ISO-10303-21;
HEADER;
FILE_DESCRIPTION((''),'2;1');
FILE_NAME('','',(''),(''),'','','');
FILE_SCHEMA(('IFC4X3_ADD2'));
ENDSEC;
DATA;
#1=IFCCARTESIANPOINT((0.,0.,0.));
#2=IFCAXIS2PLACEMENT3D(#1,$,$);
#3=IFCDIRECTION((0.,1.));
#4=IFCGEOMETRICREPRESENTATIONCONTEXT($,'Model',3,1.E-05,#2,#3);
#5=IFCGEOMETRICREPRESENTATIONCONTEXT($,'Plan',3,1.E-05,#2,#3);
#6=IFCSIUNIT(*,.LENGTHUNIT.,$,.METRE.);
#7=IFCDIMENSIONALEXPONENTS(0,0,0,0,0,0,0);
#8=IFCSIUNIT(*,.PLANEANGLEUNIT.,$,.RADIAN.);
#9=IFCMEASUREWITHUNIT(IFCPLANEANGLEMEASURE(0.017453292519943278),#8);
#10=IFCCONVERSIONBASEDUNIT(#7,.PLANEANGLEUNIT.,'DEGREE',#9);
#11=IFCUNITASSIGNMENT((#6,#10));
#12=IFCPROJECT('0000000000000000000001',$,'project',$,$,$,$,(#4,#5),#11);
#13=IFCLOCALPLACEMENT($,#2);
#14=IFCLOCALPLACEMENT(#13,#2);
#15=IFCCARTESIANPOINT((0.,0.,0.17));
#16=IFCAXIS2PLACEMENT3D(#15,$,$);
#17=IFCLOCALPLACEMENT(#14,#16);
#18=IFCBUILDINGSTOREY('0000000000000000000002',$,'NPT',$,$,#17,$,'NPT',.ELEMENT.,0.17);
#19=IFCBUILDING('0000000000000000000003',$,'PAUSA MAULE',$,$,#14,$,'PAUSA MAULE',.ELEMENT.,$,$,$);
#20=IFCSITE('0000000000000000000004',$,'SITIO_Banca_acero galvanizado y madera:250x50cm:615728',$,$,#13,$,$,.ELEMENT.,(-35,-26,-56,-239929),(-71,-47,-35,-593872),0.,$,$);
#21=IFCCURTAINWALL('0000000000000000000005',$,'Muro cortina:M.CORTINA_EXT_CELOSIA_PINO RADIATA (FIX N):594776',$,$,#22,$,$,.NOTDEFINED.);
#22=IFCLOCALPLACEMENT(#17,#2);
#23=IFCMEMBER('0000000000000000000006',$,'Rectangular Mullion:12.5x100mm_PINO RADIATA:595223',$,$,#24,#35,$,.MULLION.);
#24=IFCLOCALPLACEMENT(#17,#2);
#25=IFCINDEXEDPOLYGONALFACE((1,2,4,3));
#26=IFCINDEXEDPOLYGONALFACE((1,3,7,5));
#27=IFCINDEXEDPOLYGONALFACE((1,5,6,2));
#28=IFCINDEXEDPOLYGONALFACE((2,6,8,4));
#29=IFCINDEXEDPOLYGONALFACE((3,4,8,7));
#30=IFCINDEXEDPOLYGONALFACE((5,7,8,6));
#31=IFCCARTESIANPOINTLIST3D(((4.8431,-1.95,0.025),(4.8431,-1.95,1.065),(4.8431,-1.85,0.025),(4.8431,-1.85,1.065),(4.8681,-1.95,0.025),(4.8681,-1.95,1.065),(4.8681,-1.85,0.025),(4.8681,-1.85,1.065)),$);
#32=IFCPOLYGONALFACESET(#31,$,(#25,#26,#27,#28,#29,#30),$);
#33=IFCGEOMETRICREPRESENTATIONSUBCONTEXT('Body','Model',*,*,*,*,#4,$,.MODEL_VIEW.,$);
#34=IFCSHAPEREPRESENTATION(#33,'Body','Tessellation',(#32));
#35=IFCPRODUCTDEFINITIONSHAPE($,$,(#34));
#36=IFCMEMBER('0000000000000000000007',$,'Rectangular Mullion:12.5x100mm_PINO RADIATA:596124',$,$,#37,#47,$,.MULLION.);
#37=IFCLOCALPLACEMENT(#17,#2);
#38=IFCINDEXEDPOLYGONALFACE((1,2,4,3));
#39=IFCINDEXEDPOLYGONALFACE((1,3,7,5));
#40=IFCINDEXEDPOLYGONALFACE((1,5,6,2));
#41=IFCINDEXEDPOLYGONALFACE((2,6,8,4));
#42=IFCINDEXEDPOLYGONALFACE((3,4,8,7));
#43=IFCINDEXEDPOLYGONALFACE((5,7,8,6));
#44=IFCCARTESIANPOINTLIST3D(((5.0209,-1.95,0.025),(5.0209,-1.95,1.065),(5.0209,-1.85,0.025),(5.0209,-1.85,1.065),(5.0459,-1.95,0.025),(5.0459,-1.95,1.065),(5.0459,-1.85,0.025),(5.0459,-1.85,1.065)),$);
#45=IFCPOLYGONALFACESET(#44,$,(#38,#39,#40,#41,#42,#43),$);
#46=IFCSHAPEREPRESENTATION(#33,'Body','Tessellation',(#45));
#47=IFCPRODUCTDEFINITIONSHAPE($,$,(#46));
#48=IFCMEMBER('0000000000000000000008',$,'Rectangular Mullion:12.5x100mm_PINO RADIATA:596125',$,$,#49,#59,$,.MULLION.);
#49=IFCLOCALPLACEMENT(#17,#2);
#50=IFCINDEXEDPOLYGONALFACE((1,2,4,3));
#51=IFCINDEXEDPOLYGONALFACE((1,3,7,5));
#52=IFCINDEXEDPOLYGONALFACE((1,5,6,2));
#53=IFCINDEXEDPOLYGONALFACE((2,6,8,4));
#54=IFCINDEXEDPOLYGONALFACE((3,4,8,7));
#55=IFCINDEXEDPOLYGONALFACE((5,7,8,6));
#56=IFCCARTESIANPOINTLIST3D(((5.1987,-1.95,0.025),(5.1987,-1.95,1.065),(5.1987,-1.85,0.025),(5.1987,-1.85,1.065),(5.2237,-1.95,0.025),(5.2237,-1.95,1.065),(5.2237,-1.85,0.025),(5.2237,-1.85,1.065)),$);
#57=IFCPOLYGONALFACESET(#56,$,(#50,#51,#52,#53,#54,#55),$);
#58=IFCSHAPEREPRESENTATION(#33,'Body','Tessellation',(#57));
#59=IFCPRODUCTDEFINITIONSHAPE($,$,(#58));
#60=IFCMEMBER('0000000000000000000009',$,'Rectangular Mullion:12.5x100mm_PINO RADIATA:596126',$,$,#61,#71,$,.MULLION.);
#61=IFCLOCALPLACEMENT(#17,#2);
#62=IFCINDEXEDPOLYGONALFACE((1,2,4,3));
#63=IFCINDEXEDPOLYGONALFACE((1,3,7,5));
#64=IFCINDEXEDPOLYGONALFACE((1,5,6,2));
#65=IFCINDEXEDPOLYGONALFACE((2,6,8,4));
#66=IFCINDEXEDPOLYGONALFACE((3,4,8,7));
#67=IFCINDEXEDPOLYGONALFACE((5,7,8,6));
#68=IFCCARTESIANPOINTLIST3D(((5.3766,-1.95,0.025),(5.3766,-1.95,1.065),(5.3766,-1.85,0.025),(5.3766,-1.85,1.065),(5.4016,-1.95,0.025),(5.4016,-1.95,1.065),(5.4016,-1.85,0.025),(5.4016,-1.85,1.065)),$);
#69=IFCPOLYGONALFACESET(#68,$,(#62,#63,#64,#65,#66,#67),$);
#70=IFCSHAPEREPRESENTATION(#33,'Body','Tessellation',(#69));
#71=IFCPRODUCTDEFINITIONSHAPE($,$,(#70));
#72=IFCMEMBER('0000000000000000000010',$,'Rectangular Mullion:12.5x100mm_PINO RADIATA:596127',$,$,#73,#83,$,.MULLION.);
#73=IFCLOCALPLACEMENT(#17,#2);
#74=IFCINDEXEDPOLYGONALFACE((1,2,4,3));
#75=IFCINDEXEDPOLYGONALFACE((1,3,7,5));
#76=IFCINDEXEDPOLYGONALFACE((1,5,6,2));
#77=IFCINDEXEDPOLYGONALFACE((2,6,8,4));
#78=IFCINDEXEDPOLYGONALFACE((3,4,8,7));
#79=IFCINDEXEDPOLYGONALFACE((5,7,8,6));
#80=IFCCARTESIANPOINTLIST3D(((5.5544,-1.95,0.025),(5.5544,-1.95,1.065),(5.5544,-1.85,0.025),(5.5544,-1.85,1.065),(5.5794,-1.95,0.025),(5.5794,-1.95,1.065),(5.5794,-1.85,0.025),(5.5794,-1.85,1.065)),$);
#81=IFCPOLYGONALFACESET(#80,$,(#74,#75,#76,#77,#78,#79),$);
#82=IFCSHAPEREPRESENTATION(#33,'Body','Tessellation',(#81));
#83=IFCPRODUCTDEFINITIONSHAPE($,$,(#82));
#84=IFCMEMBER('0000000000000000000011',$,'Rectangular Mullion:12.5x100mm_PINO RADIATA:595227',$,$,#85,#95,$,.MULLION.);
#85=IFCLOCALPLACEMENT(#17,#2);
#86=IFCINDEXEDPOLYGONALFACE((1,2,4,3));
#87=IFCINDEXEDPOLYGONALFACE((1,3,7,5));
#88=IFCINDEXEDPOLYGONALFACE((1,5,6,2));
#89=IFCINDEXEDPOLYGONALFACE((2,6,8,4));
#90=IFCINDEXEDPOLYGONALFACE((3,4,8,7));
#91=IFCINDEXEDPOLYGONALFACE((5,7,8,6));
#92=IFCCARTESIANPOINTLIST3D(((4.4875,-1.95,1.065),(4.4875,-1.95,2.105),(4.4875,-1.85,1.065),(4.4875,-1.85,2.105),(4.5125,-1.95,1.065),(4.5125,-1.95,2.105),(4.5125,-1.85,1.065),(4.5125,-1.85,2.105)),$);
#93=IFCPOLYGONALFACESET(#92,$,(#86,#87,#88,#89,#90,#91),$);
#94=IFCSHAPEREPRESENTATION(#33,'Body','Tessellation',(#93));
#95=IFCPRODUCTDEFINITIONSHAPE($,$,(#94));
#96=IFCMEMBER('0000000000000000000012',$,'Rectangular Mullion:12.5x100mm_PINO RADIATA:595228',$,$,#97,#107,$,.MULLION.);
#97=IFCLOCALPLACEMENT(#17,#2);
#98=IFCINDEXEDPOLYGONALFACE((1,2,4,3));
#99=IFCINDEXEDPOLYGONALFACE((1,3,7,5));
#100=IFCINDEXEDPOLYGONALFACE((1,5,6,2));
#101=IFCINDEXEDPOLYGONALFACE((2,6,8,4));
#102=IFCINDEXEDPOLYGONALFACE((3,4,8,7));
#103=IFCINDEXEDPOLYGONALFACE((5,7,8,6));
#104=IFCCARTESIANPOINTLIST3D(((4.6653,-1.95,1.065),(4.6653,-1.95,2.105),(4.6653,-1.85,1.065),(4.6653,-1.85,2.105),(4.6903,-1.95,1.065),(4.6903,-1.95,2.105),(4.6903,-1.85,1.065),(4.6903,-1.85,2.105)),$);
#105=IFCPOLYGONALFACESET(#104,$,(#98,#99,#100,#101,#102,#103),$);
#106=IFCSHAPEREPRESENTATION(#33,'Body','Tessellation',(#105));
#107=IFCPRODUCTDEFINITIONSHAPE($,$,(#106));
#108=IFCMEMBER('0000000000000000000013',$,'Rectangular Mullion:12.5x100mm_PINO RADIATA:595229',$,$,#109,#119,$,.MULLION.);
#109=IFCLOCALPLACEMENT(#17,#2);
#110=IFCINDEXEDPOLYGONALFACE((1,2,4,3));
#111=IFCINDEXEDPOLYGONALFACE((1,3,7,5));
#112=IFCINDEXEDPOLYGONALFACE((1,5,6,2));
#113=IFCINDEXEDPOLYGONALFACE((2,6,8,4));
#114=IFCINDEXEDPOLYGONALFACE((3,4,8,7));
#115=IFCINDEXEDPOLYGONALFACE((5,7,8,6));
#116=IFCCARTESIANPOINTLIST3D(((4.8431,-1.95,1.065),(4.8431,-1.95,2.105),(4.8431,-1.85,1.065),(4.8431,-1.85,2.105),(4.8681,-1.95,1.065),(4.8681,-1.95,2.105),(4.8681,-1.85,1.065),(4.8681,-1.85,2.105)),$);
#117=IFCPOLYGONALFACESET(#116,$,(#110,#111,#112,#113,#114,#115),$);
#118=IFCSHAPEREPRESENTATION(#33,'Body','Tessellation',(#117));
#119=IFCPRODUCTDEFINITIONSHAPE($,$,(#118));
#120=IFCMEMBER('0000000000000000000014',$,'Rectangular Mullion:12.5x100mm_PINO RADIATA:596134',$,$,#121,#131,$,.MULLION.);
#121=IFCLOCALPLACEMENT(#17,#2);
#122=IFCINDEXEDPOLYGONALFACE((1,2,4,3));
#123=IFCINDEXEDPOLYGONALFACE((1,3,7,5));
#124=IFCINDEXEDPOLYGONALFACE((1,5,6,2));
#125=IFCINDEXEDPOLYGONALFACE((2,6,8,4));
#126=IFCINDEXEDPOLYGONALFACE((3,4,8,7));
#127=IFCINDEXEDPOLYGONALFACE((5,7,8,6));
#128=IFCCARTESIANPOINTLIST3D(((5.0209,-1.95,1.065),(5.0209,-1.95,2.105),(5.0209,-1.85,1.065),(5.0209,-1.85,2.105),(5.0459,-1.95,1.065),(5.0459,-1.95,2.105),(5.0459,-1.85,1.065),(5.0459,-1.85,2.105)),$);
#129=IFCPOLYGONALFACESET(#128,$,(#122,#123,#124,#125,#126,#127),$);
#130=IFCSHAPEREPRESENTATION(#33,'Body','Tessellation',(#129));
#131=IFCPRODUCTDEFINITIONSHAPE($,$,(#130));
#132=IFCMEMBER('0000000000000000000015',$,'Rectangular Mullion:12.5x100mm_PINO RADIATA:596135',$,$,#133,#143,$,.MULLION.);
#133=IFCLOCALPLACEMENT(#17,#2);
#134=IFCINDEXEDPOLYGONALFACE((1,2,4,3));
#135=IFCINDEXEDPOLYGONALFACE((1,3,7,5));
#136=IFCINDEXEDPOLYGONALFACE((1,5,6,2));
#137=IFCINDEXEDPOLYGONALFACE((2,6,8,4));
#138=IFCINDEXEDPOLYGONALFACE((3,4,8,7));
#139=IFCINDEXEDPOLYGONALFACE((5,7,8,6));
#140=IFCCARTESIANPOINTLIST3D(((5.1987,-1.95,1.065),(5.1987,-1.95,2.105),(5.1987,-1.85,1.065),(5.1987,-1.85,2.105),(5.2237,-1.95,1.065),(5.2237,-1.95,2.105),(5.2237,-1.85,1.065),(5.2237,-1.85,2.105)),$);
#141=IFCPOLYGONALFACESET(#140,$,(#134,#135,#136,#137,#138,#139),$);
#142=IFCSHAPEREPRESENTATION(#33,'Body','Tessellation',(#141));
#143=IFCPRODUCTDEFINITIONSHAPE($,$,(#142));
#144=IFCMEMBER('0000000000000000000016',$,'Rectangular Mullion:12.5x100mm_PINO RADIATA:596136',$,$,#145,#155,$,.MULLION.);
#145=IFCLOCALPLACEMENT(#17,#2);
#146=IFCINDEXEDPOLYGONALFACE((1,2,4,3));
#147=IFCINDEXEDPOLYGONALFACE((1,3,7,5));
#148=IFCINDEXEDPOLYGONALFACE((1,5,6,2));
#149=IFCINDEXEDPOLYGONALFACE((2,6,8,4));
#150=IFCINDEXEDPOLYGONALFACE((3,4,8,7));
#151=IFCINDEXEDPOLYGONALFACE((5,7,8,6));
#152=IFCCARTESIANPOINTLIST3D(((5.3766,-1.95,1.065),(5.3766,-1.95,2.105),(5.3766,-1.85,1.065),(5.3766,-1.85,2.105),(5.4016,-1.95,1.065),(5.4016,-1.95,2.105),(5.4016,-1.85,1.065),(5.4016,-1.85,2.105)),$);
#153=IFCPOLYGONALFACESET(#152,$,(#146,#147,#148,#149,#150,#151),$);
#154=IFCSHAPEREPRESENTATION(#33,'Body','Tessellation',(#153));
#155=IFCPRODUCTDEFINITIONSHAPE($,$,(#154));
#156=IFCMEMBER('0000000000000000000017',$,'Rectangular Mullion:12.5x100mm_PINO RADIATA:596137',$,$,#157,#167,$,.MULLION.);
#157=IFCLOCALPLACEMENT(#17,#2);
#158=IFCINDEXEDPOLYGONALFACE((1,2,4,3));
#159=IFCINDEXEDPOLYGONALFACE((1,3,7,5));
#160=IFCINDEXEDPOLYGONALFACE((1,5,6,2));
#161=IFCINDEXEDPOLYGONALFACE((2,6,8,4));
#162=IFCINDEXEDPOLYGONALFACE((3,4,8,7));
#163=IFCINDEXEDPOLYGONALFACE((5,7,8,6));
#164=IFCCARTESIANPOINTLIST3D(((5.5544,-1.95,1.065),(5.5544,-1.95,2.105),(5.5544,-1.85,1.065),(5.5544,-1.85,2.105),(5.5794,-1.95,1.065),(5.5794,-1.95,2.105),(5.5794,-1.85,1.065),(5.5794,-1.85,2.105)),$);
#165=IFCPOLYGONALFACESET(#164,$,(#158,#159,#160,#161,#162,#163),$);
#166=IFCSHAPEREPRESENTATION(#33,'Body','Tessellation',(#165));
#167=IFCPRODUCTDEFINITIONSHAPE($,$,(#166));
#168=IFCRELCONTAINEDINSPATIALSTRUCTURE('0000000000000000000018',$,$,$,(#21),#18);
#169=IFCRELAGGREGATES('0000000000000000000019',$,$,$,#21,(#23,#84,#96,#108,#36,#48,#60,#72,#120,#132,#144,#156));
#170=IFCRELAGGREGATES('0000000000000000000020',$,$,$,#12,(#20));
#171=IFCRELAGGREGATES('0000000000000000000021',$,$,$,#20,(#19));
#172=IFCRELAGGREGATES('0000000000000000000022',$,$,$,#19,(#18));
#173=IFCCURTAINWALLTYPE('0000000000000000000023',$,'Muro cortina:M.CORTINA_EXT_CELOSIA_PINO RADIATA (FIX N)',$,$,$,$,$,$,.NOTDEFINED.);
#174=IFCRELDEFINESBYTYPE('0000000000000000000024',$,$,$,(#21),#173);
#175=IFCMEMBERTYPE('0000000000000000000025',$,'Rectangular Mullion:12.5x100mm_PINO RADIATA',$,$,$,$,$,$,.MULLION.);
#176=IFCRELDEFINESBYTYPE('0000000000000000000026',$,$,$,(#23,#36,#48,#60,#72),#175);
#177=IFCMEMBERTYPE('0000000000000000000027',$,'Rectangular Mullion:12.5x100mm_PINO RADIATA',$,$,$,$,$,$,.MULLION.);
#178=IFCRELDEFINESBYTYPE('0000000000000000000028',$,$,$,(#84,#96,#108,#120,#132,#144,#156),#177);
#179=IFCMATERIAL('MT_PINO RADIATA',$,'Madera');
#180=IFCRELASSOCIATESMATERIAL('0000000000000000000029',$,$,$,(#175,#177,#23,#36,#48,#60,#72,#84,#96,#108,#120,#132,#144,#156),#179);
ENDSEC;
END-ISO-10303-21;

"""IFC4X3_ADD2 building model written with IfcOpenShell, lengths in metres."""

from ifc_helpers import new_model, entity, si_unit, converted_unit, direction, frame, frame_2d, origin, origin_2d_with_axis, place, context, subcontext, project, spatial, rectangle, extrude, source, transform, mapped, material, material_profile, profile_set, profile_usage, type_object, type_shapes, element, aggregate, save


model = new_model("IFC4X3_ADD2")

# Units and contexts
model_context = context("Model", 3, precision=1e-05, world=origin(), true_north=direction((0.0, 1.0)))
plan_context = context("Plan", 3, precision=1e-05, world=origin(), true_north=direction((0.0, 1.0)))
body_context = subcontext(model_context, "Body", "Model", "MODEL_VIEW")
ifc_project = project(units=[si_unit("LENGTHUNIT", "METRE"), converted_unit("PLANEANGLEUNIT", "DEGREE", entity("IfcPlaneAngleMeasure", 0.017453292519943278), si_unit("PLANEANGLEUNIT", "RADIAN"), dimensions=[0, 0, 0, 0, 0, 0, 0])], contexts=[model_context, plan_context])

# Site, building, storey
site_placement = place(None, origin())
site = spatial("IfcSite", under=ifc_project, at=site_placement, Name="SITIO_Banca_acero galvanizado y madera:250x50cm:615728", CompositionType="ELEMENT", RefLatitude=(-35, -26, -56, -239929), RefLongitude=(-71, -47, -35, -593872), RefElevation=0.0)
building_placement = place(site_placement, origin())
building = spatial("IfcBuilding", under=site, at=building_placement, Name="PAUSA MAULE", LongName="PAUSA MAULE", CompositionType="ELEMENT")
storey_placement = place(building_placement, frame((0.0, 0.0, 0.17)))
storey = spatial("IfcBuildingStorey", under=building, at=storey_placement, Name="NPT", LongName="NPT", CompositionType="ELEMENT", Elevation=0.17)

# Curtain wall, members
curtain_wall_type = type_object("IfcCurtainWallType", Name="Muro cortina:M.CORTINA_EXT_CELOSIA_PINO RADIATA (FIX N)", PredefinedType="NOTDEFINED")
curtain_wall_placement = place(storey_placement, frame((0.0, 0.0, -0.17)))
curtain_wall = element("IfcCurtainWall", 1, at=curtain_wall_placement, inside=storey, type_object=curtain_wall_type, Name="Muro cortina:M.CORTINA_EXT_CELOSIA_PINO RADIATA (FIX N):594776", PredefinedType="NOTDEFINED")
ifc_material = material(Name="MT_PINO RADIATA", Category="Madera")
ifc_material_profile = material_profile(ifc_material, rectangle(XDim=0.025, YDim=0.1, at=frame_2d((0.0, 0.0), x_axis=(1.0, 0.0))), Name="12.5x100mm_PINO RADIATA")
ifc_profile_set = profile_set([ifc_material_profile], Name="12.5x100mm_PINO RADIATA")
ifc_profile_usage = profile_usage(ifc_profile_set)
member_type_1 = type_object("IfcMemberType", Name="Rectangular Mullion:12.5x100mm_PINO RADIATA", PredefinedType="MULLION", material=ifc_profile_set)
shared_shape_1 = source(origin(), body_context, "Body", "SweptSolid", [
    extrude(rectangle(XDim=0.025, YDim=0.1, at=frame_2d((0.0, 0.0), x_axis=(1.0, 0.0))), frame((0.0, 0.0, -1.04), z_axis=(0.0, 0.0, 1.0), x_axis=(-1.0, 0.0, 0.0)), (0.0, 0.0, 1.0), 1.04),
])
type_shapes(member_type_1, [shared_shape_1])
member_1_placement = place(curtain_wall_placement, frame((4.8556, -1.9, 0.195), z_axis=(0.0, 0.0, -1.0), x_axis=(1.0, 0.0, 0.0)))
member_1 = element("IfcMember", 2, at=member_1_placement, type_object=member_type_1, material=ifc_profile_usage, Name="Rectangular Mullion:12.5x100mm_PINO RADIATA:595223", PredefinedType="MULLION", context=body_context, shape_type="MappedRepresentation", body=[
    mapped(shared_shape_1, transform((0.0, 0.0, 0.0), scale=1.0)),
])
member_2_placement = place(curtain_wall_placement, frame((5.0334, -1.9, 0.195), z_axis=(0.0, 0.0, -1.0), x_axis=(1.0, 0.0, 0.0)))
member_2 = element("IfcMember", 3, at=member_2_placement, type_object=member_type_1, material=ifc_profile_usage, Name="Rectangular Mullion:12.5x100mm_PINO RADIATA:596124", PredefinedType="MULLION", context=body_context, shape_type="MappedRepresentation", body=[
    mapped(shared_shape_1, transform((0.0, 0.0, 0.0), scale=1.0)),
])
member_3_placement = place(curtain_wall_placement, frame((5.2112, -1.9, 0.195), z_axis=(0.0, 0.0, -1.0), x_axis=(1.0, 0.0, 0.0)))
member_3 = element("IfcMember", 4, at=member_3_placement, type_object=member_type_1, material=ifc_profile_usage, Name="Rectangular Mullion:12.5x100mm_PINO RADIATA:596125", PredefinedType="MULLION", context=body_context, shape_type="MappedRepresentation", body=[
    mapped(shared_shape_1, transform((0.0, 0.0, 0.0), scale=1.0)),
])
member_4_placement = place(curtain_wall_placement, frame((5.3891, -1.9, 0.195), z_axis=(0.0, 0.0, -1.0), x_axis=(1.0, 0.0, 0.0)))
member_4 = element("IfcMember", 5, at=member_4_placement, type_object=member_type_1, material=ifc_profile_usage, Name="Rectangular Mullion:12.5x100mm_PINO RADIATA:596126", PredefinedType="MULLION", context=body_context, shape_type="MappedRepresentation", body=[
    mapped(shared_shape_1, transform((0.0, 0.0, 0.0), scale=1.0)),
])
member_5_placement = place(curtain_wall_placement, frame((5.5669, -1.9, 0.195), z_axis=(0.0, 0.0, -1.0), x_axis=(1.0, 0.0, 0.0)))
member_5 = element("IfcMember", 6, at=member_5_placement, type_object=member_type_1, material=ifc_profile_usage, Name="Rectangular Mullion:12.5x100mm_PINO RADIATA:596127", PredefinedType="MULLION", context=body_context, shape_type="MappedRepresentation", body=[
    mapped(shared_shape_1, transform((0.0, 0.0, 0.0), scale=1.0)),
])
member_type_2 = type_object("IfcMemberType", Name="Rectangular Mullion:12.5x100mm_PINO RADIATA", PredefinedType="MULLION", material=ifc_profile_set)
shared_shape_2 = source(origin(), body_context, "Body", "SweptSolid", [
    extrude(rectangle(XDim=0.025, YDim=0.1, at=origin_2d_with_axis()), frame((0.0, 0.0, -1.04), z_axis=(0.0, 0.0, 1.0), x_axis=(-1.0, 0.0, 0.0)), (0.0, 0.0, 1.0), 1.04),
])
type_shapes(member_type_2, [shared_shape_2])
member_6_placement = place(curtain_wall_placement, frame((4.5, -1.9, 1.235), z_axis=(0.0, 0.0, -1.0), x_axis=(1.0, 0.0, 0.0)))
member_6 = element("IfcMember", 7, at=member_6_placement, type_object=member_type_2, material=ifc_profile_usage, Name="Rectangular Mullion:12.5x100mm_PINO RADIATA:595227", PredefinedType="MULLION", context=body_context, shape_type="MappedRepresentation", body=[
    mapped(shared_shape_2, transform((0.0, 0.0, 0.0), scale=1.0)),
])
member_7_placement = place(curtain_wall_placement, frame((4.6778, -1.9, 1.235), z_axis=(0.0, 0.0, -1.0), x_axis=(1.0, 0.0, 0.0)))
member_7 = element("IfcMember", 8, at=member_7_placement, type_object=member_type_2, material=ifc_profile_usage, Name="Rectangular Mullion:12.5x100mm_PINO RADIATA:595228", PredefinedType="MULLION", context=body_context, shape_type="MappedRepresentation", body=[
    mapped(shared_shape_2, transform((0.0, 0.0, 0.0), scale=1.0)),
])
member_8_placement = place(curtain_wall_placement, frame((4.8556, -1.9, 1.235), z_axis=(0.0, 0.0, -1.0), x_axis=(1.0, 0.0, 0.0)))
member_8 = element("IfcMember", 9, at=member_8_placement, type_object=member_type_2, material=ifc_profile_usage, Name="Rectangular Mullion:12.5x100mm_PINO RADIATA:595229", PredefinedType="MULLION", context=body_context, shape_type="MappedRepresentation", body=[
    mapped(shared_shape_2, transform((0.0, 0.0, 0.0), scale=1.0)),
])
member_9_placement = place(curtain_wall_placement, frame((5.0334, -1.9, 1.235), z_axis=(0.0, 0.0, -1.0), x_axis=(1.0, 0.0, 0.0)))
member_9 = element("IfcMember", 10, at=member_9_placement, type_object=member_type_2, material=ifc_profile_usage, Name="Rectangular Mullion:12.5x100mm_PINO RADIATA:596134", PredefinedType="MULLION", context=body_context, shape_type="MappedRepresentation", body=[
    mapped(shared_shape_2, transform((0.0, 0.0, 0.0), scale=1.0)),
])
member_10_placement = place(curtain_wall_placement, frame((5.2112, -1.9, 1.235), z_axis=(0.0, 0.0, -1.0), x_axis=(1.0, 0.0, 0.0)))
member_10 = element("IfcMember", 11, at=member_10_placement, type_object=member_type_2, material=ifc_profile_usage, Name="Rectangular Mullion:12.5x100mm_PINO RADIATA:596135", PredefinedType="MULLION", context=body_context, shape_type="MappedRepresentation", body=[
    mapped(shared_shape_2, transform((0.0, 0.0, 0.0), scale=1.0)),
])
member_11_placement = place(curtain_wall_placement, frame((5.3891, -1.9, 1.235), z_axis=(0.0, 0.0, -1.0), x_axis=(1.0, 0.0, 0.0)))
member_11 = element("IfcMember", 12, at=member_11_placement, type_object=member_type_2, material=ifc_profile_usage, Name="Rectangular Mullion:12.5x100mm_PINO RADIATA:596136", PredefinedType="MULLION", context=body_context, shape_type="MappedRepresentation", body=[
    mapped(shared_shape_2, transform((0.0, 0.0, 0.0), scale=1.0)),
])
member_12_placement = place(curtain_wall_placement, frame((5.5669, -1.9, 1.235), z_axis=(0.0, 0.0, -1.0), x_axis=(1.0, 0.0, 0.0)))
member_12 = element("IfcMember", 13, at=member_12_placement, type_object=member_type_2, material=ifc_profile_usage, Name="Rectangular Mullion:12.5x100mm_PINO RADIATA:596137", PredefinedType="MULLION", context=body_context, shape_type="MappedRepresentation", body=[
    mapped(shared_shape_2, transform((0.0, 0.0, 0.0), scale=1.0)),
])
aggregate(curtain_wall, [member_1, member_6, member_7, member_8, member_2, member_3, member_4, member_5, member_9, member_10, member_11, member_12])

save(model, "model.ifc")
